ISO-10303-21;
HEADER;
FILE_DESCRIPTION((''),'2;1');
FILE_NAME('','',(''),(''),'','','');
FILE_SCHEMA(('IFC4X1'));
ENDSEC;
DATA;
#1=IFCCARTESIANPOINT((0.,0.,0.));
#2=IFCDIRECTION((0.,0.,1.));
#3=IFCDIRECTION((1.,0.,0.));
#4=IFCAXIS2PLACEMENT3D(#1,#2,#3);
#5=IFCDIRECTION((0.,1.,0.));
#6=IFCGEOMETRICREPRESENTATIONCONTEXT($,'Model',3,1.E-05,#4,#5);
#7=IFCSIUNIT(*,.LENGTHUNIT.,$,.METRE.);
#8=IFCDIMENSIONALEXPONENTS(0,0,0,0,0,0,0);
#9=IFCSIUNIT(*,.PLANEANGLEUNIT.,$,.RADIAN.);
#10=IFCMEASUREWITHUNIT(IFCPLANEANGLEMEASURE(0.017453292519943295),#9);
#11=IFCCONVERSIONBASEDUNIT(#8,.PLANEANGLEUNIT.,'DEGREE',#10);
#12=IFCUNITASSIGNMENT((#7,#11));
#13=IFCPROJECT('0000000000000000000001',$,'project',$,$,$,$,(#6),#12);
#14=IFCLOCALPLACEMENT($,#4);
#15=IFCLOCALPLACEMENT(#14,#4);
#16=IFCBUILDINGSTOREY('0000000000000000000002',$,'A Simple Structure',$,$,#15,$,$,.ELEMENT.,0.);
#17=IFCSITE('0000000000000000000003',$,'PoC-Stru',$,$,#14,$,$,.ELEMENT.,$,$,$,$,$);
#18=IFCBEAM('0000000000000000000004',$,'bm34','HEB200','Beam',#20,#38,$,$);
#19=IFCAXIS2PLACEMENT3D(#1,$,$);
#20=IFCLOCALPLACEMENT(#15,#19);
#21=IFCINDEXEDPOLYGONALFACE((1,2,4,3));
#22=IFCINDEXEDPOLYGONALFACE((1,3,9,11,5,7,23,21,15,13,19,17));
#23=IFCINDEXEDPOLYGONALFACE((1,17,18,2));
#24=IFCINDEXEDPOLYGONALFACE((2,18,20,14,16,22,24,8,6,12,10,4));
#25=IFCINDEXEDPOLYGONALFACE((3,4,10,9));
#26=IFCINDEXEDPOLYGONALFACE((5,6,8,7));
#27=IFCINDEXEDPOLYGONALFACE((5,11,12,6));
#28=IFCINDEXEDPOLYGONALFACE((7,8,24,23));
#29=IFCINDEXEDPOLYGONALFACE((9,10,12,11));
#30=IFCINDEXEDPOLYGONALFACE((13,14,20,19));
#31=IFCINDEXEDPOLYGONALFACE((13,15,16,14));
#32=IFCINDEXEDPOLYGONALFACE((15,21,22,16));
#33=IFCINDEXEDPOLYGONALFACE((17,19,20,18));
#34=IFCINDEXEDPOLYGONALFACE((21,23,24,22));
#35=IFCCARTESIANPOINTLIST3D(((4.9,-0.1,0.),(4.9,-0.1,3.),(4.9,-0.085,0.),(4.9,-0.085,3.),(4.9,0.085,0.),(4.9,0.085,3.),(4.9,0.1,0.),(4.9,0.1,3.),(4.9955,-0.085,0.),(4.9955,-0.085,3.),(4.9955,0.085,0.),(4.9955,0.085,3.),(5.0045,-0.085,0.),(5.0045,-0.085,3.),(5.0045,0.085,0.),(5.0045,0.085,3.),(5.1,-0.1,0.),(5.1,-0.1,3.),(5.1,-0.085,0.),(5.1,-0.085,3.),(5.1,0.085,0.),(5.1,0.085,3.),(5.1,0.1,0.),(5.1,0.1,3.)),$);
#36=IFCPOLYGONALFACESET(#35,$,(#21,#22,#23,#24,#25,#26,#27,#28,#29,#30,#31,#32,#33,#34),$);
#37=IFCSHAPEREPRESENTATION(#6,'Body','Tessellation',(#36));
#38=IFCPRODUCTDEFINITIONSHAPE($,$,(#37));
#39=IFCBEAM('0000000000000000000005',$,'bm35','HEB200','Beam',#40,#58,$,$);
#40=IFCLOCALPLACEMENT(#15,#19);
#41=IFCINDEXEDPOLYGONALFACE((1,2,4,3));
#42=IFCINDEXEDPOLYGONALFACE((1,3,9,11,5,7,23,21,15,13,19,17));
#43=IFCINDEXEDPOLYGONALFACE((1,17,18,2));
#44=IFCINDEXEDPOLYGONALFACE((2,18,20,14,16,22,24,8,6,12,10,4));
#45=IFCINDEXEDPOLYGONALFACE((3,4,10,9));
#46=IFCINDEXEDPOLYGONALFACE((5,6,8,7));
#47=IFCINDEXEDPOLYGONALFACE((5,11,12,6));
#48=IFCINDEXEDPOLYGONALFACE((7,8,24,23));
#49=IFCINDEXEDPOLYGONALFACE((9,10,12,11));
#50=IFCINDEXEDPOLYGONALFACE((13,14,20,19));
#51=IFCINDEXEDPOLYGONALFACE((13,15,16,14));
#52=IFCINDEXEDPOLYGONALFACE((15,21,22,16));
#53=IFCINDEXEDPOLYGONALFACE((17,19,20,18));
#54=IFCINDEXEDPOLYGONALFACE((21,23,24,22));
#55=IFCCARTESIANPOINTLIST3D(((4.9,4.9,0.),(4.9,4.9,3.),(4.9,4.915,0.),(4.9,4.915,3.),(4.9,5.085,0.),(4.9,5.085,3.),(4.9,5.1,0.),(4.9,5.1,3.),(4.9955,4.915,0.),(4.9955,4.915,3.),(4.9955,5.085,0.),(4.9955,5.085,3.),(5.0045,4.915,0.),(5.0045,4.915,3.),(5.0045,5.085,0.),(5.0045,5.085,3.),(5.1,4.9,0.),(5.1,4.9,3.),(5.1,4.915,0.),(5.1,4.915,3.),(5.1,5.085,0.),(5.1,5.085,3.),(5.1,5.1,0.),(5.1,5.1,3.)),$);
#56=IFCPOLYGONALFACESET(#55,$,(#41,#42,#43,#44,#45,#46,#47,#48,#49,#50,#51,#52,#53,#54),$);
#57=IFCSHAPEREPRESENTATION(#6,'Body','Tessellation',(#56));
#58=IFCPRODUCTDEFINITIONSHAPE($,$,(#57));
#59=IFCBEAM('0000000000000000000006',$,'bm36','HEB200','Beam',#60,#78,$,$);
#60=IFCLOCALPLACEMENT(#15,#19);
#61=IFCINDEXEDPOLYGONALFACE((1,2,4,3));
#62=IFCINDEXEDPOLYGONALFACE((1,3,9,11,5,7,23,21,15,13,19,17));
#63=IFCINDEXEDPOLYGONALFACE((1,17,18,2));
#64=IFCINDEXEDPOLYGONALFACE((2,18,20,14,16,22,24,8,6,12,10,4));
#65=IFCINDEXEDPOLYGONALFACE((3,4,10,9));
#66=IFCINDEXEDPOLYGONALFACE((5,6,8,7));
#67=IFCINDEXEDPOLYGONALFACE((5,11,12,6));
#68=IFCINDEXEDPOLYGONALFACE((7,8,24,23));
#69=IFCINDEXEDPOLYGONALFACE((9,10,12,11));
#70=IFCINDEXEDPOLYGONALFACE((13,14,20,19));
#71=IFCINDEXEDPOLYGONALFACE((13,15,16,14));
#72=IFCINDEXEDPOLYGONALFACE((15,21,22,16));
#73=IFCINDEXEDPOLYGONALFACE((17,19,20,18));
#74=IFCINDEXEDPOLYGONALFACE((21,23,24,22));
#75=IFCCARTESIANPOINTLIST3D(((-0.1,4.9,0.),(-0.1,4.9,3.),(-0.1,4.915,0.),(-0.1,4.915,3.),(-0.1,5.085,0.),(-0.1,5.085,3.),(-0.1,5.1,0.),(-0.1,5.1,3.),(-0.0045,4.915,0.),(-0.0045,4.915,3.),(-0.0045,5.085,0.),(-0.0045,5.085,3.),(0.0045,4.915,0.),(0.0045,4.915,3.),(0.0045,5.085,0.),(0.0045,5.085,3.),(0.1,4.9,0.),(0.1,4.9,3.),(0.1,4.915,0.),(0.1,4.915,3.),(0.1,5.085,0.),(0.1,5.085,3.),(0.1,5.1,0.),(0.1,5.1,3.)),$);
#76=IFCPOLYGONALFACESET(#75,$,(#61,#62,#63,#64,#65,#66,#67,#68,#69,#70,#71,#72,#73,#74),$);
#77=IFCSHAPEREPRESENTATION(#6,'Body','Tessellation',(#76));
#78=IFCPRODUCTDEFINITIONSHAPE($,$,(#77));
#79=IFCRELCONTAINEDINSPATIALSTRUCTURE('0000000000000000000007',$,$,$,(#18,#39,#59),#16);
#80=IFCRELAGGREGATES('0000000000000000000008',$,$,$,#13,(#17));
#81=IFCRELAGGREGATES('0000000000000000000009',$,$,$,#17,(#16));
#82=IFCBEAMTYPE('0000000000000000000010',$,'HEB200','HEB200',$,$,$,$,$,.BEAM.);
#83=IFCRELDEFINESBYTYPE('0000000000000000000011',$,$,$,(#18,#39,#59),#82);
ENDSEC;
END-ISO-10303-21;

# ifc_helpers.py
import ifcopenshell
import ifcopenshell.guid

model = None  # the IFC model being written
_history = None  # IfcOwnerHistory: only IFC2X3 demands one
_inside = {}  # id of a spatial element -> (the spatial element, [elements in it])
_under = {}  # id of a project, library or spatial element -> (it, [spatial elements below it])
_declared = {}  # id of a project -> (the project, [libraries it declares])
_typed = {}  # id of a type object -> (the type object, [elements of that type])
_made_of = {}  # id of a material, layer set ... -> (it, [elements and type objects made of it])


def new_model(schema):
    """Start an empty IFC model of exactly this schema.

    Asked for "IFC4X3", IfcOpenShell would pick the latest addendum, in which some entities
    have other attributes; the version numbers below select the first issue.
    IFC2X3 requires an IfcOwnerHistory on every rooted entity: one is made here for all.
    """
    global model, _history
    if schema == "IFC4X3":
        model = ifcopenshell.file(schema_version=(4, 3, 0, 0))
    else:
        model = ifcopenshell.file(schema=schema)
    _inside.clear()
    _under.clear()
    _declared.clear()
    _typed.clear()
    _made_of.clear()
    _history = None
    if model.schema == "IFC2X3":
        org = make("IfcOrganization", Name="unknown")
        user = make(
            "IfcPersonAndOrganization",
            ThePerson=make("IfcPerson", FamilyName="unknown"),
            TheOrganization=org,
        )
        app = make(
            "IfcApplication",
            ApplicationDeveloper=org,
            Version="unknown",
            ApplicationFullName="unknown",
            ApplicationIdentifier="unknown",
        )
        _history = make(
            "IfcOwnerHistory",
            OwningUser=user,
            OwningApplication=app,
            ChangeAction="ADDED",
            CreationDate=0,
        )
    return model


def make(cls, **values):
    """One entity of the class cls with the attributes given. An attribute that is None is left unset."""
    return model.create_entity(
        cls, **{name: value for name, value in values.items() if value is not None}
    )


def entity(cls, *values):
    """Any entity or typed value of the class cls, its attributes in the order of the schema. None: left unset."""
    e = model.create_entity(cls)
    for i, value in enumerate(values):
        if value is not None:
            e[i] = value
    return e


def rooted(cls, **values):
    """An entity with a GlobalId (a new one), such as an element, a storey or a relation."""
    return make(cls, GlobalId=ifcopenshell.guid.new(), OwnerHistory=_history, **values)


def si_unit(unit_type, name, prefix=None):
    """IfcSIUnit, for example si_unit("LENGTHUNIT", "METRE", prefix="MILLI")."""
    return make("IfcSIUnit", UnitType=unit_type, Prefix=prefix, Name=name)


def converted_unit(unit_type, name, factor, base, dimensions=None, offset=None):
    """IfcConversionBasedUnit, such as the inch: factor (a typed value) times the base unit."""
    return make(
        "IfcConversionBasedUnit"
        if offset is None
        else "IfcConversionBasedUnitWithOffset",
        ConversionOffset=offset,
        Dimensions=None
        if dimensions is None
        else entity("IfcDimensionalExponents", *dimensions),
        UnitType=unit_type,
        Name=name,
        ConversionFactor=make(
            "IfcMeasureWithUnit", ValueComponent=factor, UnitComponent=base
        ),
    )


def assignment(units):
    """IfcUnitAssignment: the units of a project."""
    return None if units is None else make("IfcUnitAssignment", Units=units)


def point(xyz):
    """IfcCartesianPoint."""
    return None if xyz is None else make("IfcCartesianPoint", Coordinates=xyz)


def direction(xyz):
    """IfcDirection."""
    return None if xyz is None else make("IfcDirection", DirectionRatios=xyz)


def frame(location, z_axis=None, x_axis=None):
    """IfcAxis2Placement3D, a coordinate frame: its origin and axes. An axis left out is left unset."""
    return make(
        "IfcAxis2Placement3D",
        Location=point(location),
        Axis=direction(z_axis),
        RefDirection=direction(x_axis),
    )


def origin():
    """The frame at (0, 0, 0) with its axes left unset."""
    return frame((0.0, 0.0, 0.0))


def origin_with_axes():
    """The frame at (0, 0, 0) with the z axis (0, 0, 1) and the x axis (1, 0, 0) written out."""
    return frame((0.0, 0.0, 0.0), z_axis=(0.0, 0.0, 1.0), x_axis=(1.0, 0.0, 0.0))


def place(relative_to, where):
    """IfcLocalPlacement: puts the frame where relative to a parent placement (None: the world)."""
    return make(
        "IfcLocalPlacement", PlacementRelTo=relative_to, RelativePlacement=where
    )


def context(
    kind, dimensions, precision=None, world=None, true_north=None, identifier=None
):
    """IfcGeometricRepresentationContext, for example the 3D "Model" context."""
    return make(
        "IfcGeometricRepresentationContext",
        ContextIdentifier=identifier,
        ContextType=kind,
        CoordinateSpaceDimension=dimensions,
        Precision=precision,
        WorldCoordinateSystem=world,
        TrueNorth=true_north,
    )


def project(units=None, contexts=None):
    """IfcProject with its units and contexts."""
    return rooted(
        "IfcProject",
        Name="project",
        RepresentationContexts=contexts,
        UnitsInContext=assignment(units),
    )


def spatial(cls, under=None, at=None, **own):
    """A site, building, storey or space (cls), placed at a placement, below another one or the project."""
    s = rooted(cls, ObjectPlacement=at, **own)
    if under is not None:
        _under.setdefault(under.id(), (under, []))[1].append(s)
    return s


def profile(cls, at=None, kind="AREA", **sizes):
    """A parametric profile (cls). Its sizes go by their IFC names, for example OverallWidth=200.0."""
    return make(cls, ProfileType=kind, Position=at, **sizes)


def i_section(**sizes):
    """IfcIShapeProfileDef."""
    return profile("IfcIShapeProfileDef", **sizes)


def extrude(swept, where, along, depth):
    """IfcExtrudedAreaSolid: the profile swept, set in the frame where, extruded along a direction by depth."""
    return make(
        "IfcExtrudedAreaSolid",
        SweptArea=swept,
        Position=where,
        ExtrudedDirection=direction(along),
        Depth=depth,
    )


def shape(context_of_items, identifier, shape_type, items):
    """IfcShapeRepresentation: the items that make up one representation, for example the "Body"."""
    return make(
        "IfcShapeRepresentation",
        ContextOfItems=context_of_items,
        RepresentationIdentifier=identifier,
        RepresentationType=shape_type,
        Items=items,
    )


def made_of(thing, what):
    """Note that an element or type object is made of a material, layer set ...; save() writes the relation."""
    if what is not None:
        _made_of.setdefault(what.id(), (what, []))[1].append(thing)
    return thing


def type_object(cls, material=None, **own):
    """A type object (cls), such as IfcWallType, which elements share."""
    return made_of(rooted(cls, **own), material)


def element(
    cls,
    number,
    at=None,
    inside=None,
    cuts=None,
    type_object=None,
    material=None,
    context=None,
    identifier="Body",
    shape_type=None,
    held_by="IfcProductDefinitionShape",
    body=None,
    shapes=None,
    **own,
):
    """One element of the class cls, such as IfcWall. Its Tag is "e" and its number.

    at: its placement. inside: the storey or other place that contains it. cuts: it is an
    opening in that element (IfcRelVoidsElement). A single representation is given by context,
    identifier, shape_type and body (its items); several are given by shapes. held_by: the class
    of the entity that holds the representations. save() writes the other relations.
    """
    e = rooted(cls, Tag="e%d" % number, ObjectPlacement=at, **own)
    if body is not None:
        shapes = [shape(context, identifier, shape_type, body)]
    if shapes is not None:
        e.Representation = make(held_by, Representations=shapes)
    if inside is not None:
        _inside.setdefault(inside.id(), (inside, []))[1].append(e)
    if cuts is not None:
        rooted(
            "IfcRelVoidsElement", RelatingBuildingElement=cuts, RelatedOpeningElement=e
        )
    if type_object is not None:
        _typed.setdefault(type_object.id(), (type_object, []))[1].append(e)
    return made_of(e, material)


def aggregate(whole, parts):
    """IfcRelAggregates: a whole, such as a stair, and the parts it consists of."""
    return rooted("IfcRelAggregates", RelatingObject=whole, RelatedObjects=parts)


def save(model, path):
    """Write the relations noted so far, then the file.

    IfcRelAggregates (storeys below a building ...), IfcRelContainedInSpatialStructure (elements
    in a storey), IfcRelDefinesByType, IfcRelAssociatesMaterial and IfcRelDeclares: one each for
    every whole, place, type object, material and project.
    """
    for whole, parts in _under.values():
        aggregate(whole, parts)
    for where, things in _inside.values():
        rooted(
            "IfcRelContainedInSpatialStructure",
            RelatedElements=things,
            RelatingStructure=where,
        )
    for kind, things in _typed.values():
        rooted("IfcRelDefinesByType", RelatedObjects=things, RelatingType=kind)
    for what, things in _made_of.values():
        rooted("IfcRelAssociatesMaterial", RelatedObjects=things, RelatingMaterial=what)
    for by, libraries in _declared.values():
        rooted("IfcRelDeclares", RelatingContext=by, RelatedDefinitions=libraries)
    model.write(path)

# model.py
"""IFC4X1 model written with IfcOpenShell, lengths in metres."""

from ifc_helpers import new_model, entity, si_unit, converted_unit, direction, frame, origin, origin_with_axes, place, context, project, spatial, i_section, extrude, type_object, element, save


model = new_model("IFC4X1")

# Units and contexts
model_context = context("Model", 3, precision=1e-05, world=origin_with_axes(), true_north=direction((0.0, 1.0, 0.0)))
ifc_project = project(units=[si_unit("LENGTHUNIT", "METRE"), converted_unit("PLANEANGLEUNIT", "DEGREE", entity("IfcPlaneAngleMeasure", 0.017453292519943295), si_unit("PLANEANGLEUNIT", "RADIAN"), dimensions=[0, 0, 0, 0, 0, 0, 0])], contexts=[model_context])

# Site, storey
site_placement = place(None, origin_with_axes())
site = spatial("IfcSite", under=ifc_project, at=site_placement, Name="PoC-Stru", CompositionType="ELEMENT")
storey_placement = place(site_placement, origin_with_axes())
storey = spatial("IfcBuildingStorey", under=site, at=storey_placement, Name="A Simple Structure", CompositionType="ELEMENT", Elevation=0.0)

# Beams
beam_type_1 = type_object("IfcBeamType", Name="HEB200", Description="HEB200", PredefinedType="BEAM")
placement_1 = place(storey_placement, origin_with_axes())
beam_1_placement = place(placement_1, frame((5.0, 0.0, 0.0), z_axis=(0.0, 0.0, 1.0), x_axis=(1.0, 0.0, 0.0)))
element("IfcBeam", 1, at=beam_1_placement, inside=storey, type_object=beam_type_1, Name="bm34", Description="HEB200", ObjectType="Beam", context=model_context, shape_type="SweptSolid", body=[
    extrude(i_section(OverallWidth=0.2, OverallDepth=0.2, WebThickness=0.009, FlangeThickness=0.015), origin(), (0.0, 0.0, 1.0), 3.0),
])
placement_2 = place(storey_placement, origin_with_axes())
beam_2_placement = place(placement_2, frame((5.0, 5.0, 0.0), z_axis=(0.0, 0.0, 1.0), x_axis=(1.0, 0.0, 0.0)))
element("IfcBeam", 2, at=beam_2_placement, inside=storey, type_object=beam_type_1, Name="bm35", Description="HEB200", ObjectType="Beam", context=model_context, shape_type="SweptSolid", body=[
    extrude(i_section(OverallWidth=0.2, OverallDepth=0.2, WebThickness=0.009, FlangeThickness=0.015), origin(), (0.0, 0.0, 1.0), 3.0),
])
placement_3 = place(storey_placement, origin_with_axes())
beam_3_placement = place(placement_3, frame((0.0, 5.0, 0.0), z_axis=(0.0, 0.0, 1.0), x_axis=(1.0, 0.0, 0.0)))
element("IfcBeam", 3, at=beam_3_placement, inside=storey, type_object=beam_type_1, Name="bm36", Description="HEB200", ObjectType="Beam", context=model_context, shape_type="SweptSolid", body=[
    extrude(i_section(OverallWidth=0.2, OverallDepth=0.2, WebThickness=0.009, FlangeThickness=0.015), origin(), (0.0, 0.0, 1.0), 3.0),
])

save(model, "model.ifc")
